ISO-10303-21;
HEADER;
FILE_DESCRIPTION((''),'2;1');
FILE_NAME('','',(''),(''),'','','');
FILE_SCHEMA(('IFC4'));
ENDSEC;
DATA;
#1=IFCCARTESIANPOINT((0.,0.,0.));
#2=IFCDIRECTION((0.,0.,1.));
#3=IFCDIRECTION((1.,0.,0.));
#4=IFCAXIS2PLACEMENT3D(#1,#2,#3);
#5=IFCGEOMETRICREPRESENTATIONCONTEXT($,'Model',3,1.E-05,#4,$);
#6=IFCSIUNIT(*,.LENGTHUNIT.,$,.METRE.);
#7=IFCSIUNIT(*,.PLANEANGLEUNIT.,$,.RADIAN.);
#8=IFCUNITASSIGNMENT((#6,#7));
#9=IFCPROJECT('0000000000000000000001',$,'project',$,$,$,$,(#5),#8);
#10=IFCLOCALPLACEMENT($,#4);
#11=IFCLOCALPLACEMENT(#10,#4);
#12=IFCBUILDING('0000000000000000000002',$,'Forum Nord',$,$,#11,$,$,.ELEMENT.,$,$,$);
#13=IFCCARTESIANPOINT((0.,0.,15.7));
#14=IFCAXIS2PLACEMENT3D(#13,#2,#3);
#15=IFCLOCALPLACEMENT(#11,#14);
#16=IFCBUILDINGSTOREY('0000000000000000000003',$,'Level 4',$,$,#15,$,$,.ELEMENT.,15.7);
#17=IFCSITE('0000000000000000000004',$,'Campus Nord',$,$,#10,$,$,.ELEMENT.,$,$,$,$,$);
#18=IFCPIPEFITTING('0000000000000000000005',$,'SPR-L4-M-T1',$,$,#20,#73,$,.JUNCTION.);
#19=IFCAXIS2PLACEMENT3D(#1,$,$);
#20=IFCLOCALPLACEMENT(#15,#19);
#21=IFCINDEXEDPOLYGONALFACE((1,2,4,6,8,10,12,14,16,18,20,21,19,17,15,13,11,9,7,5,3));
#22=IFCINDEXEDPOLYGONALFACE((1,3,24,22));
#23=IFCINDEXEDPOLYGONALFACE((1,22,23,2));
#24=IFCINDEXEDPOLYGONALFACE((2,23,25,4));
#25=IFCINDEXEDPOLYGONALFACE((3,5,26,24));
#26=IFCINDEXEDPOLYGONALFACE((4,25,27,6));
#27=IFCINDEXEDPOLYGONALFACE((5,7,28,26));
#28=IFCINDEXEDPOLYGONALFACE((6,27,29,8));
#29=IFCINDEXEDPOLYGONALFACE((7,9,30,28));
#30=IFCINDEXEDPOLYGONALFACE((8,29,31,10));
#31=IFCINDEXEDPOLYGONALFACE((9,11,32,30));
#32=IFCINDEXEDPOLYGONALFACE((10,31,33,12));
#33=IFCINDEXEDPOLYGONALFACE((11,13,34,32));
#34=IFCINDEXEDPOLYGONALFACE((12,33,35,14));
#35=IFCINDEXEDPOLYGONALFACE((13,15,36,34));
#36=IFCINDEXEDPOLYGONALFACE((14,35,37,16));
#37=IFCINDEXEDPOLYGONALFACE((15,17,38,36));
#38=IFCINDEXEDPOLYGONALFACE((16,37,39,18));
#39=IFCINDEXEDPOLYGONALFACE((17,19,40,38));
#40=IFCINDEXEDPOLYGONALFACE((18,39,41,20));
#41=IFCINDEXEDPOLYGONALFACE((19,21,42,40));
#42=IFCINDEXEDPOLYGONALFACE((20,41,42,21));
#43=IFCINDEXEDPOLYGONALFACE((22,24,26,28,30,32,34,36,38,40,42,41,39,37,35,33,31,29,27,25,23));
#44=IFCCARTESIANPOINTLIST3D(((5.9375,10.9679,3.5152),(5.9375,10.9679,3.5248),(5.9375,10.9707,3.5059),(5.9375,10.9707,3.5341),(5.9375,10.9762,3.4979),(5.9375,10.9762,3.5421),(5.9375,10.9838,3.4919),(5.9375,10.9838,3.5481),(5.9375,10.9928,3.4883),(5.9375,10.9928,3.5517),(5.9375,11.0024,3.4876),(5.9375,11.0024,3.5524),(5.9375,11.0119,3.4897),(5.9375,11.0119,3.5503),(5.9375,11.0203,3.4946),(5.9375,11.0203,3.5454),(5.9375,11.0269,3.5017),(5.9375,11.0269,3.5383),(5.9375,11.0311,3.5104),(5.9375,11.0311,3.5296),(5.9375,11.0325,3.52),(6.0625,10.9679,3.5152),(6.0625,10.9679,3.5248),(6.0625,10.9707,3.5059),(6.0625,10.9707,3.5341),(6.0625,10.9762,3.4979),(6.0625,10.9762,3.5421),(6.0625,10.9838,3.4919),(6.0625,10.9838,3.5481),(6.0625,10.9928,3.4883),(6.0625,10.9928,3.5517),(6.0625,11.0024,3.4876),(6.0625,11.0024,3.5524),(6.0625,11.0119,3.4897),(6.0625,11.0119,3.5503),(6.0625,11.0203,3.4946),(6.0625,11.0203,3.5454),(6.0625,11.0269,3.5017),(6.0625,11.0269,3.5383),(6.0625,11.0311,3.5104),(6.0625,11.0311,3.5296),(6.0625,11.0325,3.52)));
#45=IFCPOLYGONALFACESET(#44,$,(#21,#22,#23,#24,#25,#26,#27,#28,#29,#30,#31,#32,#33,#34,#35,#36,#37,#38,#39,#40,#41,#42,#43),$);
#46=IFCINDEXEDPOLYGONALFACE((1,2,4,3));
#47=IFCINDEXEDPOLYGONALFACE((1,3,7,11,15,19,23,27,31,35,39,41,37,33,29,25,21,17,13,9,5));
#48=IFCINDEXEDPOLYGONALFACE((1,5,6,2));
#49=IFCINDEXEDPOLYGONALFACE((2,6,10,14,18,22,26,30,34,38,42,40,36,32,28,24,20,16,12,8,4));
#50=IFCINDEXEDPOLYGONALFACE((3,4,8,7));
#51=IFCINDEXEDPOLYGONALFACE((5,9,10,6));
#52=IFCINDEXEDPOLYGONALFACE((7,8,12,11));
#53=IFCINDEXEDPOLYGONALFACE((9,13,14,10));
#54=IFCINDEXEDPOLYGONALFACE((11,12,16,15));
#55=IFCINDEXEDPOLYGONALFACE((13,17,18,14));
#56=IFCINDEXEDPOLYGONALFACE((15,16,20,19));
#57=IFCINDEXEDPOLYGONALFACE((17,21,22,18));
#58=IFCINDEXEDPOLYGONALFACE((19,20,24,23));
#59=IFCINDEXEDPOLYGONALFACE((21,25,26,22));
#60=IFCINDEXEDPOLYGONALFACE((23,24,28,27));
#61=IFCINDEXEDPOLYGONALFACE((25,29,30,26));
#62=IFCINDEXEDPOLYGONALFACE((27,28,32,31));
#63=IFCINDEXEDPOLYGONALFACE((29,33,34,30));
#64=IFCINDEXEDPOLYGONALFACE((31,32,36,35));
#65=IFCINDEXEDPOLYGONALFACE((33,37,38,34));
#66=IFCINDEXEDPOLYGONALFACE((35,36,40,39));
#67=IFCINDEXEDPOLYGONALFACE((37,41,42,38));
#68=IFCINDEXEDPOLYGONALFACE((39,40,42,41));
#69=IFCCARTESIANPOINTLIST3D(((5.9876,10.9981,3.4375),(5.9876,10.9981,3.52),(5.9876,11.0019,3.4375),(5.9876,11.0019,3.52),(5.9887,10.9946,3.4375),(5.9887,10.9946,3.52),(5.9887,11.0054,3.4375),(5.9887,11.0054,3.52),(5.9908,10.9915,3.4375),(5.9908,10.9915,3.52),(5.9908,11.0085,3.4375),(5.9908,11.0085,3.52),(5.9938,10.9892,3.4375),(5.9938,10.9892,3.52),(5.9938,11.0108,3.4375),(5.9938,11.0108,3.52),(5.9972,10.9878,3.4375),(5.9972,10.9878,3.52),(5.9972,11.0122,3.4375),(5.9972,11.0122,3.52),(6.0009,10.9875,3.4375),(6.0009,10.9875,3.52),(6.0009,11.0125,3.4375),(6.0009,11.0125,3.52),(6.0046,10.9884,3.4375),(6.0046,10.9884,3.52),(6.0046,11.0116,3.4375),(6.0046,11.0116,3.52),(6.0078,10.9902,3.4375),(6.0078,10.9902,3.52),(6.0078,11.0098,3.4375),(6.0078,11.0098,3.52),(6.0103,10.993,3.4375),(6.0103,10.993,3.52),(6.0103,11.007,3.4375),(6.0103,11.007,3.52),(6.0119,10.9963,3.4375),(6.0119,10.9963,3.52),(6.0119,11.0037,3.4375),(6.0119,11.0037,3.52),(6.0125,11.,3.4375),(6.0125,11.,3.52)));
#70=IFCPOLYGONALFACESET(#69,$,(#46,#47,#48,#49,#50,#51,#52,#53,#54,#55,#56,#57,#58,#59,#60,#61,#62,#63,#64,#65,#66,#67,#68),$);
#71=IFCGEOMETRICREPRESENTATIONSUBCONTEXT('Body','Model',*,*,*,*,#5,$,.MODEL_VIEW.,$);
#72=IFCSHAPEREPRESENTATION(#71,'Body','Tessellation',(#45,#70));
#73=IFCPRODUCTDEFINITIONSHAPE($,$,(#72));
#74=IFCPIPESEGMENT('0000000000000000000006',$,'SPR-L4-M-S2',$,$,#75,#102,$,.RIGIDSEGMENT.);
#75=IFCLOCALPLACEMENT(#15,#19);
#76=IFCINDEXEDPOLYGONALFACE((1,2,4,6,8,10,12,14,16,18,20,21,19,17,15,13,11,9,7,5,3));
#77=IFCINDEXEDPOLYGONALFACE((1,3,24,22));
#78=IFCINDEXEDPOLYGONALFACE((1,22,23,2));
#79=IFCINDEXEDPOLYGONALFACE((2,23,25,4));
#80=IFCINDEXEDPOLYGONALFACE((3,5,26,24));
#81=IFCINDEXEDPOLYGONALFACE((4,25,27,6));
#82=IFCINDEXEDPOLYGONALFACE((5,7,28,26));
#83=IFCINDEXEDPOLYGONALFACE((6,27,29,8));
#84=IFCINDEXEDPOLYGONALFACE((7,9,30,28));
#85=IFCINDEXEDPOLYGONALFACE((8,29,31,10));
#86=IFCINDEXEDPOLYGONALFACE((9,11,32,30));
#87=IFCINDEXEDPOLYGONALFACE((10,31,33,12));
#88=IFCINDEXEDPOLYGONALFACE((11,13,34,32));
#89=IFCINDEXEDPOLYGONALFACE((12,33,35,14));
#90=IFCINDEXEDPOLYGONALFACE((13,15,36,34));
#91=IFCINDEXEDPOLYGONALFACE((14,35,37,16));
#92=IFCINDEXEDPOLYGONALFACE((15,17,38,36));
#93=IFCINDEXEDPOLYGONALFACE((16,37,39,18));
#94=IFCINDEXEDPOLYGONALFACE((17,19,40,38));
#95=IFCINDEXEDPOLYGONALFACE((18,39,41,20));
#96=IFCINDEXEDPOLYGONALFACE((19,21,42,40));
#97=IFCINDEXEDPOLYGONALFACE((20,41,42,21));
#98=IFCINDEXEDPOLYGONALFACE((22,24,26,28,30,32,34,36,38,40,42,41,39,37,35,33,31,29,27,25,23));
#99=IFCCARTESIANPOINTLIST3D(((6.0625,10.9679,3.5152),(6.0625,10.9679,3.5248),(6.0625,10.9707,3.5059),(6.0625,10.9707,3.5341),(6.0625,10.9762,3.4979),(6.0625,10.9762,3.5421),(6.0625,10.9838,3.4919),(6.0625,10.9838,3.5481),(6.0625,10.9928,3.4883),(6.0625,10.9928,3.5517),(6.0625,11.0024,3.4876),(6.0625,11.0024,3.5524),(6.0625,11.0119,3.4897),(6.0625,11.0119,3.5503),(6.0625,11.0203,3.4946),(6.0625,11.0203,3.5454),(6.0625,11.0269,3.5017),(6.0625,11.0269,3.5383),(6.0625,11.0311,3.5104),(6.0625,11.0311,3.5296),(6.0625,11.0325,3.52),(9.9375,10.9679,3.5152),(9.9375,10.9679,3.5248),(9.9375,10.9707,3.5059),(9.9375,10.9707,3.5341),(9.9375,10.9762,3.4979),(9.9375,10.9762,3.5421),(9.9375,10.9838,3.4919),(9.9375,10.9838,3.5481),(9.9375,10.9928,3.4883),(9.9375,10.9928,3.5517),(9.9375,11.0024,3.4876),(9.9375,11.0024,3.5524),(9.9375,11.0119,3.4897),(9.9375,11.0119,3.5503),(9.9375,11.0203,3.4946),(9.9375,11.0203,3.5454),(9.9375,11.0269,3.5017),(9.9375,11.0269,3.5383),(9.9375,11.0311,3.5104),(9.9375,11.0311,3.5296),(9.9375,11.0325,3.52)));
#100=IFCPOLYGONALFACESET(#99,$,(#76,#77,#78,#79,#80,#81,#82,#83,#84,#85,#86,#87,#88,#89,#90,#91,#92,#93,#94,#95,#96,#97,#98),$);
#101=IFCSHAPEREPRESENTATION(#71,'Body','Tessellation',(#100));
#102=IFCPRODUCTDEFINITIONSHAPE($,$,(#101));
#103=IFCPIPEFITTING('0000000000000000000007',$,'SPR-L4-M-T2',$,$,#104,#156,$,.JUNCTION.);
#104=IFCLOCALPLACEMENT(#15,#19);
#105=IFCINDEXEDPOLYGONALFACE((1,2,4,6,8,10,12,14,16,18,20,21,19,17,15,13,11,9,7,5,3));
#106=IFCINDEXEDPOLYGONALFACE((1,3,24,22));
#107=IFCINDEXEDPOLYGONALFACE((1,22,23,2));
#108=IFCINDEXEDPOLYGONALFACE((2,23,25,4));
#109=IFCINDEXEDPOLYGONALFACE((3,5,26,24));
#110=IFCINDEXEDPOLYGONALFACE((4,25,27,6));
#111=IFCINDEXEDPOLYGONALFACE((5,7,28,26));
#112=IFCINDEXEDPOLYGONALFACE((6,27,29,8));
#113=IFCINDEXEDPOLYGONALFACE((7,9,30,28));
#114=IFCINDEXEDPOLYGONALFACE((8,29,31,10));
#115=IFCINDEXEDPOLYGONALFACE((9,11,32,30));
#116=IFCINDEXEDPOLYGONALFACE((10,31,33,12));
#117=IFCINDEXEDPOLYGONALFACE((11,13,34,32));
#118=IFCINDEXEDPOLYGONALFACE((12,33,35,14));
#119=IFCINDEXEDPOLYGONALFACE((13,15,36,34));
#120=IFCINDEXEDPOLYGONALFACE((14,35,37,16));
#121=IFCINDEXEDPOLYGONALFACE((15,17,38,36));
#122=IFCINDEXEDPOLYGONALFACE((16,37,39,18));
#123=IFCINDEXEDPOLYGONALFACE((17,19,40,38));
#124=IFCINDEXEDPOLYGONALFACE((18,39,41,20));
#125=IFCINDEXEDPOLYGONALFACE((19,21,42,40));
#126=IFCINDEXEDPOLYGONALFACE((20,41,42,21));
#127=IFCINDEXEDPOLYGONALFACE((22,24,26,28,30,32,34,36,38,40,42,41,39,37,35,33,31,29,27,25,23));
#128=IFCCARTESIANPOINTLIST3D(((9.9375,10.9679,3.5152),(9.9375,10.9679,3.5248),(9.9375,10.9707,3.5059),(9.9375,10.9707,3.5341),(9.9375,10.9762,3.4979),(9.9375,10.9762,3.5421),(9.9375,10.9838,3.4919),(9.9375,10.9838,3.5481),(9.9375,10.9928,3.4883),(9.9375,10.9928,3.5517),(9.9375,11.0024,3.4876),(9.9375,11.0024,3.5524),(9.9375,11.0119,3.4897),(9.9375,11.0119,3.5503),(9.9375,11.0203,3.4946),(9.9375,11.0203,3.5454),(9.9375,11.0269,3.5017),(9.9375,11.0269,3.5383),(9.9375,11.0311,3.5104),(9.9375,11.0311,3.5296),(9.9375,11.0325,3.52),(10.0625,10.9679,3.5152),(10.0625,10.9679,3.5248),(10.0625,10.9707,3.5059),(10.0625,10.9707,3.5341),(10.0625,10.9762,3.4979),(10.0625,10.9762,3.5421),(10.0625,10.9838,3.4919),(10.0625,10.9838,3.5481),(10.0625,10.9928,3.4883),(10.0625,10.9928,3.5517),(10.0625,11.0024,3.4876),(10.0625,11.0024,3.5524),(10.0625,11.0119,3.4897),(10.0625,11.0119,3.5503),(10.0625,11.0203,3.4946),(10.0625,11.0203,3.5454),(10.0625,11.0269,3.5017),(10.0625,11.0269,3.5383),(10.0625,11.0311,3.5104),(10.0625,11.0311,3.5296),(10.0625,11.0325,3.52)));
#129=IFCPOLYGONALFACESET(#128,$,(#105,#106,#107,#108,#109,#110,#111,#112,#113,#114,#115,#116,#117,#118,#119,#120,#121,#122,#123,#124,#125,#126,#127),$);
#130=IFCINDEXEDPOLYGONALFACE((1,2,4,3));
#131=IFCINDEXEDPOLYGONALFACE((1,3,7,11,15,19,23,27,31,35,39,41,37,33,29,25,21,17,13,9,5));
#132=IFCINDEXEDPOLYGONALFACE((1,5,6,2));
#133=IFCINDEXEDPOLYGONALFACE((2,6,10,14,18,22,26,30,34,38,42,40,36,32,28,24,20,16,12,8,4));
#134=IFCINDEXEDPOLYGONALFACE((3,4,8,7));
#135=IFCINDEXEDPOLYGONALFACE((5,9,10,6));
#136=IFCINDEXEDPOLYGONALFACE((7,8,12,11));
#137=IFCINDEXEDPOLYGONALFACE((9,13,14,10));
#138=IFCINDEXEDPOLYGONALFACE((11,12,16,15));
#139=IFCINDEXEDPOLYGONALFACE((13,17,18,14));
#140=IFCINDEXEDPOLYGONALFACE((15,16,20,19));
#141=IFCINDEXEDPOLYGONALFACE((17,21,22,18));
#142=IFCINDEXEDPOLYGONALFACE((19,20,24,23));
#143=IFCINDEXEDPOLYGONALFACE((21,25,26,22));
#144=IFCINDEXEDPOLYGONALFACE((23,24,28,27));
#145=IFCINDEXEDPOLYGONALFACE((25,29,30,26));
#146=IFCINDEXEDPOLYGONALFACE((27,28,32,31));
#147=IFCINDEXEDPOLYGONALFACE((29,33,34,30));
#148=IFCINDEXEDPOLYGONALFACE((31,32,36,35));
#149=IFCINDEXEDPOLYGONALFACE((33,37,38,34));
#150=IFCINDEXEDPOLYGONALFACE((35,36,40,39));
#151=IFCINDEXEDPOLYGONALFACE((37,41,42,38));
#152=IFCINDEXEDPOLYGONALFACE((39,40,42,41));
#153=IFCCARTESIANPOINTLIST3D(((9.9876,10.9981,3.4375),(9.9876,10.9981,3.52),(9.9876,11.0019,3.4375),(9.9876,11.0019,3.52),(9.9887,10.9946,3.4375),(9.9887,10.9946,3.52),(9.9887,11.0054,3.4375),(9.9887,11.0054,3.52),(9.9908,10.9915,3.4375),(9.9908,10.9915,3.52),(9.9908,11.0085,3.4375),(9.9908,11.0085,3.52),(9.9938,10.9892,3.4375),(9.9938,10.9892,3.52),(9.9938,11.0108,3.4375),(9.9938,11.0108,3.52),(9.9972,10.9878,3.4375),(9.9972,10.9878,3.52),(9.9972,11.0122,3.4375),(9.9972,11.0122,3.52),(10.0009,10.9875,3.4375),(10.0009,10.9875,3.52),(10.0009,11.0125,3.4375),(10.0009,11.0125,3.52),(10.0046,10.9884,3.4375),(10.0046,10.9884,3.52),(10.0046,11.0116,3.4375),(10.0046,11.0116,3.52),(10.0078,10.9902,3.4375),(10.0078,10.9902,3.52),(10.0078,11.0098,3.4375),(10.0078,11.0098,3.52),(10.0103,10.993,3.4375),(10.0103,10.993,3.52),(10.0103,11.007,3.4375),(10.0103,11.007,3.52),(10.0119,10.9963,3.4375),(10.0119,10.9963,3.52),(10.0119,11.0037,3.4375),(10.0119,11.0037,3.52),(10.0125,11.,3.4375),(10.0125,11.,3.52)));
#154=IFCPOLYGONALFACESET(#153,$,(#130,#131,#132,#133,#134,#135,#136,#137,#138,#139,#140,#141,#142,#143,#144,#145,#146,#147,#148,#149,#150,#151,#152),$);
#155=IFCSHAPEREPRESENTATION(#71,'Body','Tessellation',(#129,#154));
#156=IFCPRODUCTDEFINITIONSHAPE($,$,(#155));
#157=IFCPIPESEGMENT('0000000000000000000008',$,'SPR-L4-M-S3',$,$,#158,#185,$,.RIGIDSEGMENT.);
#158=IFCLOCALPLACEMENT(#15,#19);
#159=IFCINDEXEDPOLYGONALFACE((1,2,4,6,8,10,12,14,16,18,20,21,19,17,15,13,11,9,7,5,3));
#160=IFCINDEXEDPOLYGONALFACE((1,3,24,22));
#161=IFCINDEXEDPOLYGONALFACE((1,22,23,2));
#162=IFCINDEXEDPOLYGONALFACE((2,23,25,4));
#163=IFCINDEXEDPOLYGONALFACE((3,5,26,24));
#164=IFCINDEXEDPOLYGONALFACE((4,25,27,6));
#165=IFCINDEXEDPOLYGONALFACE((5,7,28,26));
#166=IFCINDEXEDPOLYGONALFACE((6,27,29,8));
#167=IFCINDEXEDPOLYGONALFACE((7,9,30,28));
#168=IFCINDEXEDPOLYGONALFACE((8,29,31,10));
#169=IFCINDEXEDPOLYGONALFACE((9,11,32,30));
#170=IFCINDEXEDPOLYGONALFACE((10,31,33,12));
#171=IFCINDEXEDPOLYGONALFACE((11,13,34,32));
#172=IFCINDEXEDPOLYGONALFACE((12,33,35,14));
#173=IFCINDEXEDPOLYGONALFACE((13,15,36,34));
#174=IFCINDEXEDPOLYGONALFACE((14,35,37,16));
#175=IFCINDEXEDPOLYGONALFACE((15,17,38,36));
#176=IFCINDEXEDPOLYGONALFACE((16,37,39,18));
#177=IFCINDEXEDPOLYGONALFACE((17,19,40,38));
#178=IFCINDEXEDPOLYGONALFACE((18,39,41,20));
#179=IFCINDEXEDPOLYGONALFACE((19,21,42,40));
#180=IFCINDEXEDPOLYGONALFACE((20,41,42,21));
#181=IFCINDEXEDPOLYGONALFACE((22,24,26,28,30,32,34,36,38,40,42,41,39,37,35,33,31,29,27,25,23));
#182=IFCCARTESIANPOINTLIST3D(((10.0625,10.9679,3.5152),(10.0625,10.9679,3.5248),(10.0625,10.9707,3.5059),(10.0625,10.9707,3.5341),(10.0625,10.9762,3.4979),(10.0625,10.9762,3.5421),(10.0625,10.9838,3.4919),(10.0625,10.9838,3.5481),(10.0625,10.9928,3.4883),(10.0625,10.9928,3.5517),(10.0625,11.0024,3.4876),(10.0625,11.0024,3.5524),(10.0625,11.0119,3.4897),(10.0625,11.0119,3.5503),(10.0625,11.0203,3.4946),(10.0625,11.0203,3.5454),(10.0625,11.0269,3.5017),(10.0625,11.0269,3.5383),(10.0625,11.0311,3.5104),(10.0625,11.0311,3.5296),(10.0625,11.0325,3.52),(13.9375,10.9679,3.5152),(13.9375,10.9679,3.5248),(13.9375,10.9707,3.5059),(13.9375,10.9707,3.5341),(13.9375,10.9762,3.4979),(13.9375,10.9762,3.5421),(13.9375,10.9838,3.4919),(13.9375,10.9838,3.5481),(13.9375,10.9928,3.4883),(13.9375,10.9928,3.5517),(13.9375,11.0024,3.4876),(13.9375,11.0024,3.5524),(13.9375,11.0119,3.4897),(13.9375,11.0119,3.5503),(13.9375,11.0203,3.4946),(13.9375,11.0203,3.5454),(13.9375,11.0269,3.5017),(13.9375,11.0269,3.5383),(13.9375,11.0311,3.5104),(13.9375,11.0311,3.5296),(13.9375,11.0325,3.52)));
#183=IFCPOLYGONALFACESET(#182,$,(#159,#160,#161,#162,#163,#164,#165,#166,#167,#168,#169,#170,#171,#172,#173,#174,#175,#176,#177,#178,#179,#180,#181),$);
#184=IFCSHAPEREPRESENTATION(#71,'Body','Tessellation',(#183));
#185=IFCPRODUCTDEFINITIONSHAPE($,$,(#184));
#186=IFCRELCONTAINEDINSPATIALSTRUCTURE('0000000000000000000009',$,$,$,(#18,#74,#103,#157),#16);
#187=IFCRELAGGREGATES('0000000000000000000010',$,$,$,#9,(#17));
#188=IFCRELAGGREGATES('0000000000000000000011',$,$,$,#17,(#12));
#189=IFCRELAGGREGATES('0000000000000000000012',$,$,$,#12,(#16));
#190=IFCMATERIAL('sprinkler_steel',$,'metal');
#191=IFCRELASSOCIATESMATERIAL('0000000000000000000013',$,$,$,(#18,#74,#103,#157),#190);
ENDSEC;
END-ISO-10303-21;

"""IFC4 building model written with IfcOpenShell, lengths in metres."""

from ifc_helpers import new_model, si_unit, frame, origin_with_axes, origin_2d_with_axis, place, context, subcontext, project, spatial, circle, extrude, material, element, save


model = new_model("IFC4")

# Units and contexts
model_context = context("Model", 3, precision=1e-05, world=origin_with_axes())
body_context = subcontext(model_context, "Body", "Model", "MODEL_VIEW")
ifc_project = project(units=[si_unit("LENGTHUNIT", "METRE"), si_unit("PLANEANGLEUNIT", "RADIAN")], contexts=[model_context])

# Site, building, storey
site_placement = place(None, origin_with_axes())
site = spatial("IfcSite", under=ifc_project, at=site_placement, Name="Campus Nord", CompositionType="ELEMENT")
building_placement = place(site_placement, origin_with_axes())
building = spatial("IfcBuilding", under=site, at=building_placement, Name="Forum Nord", CompositionType="ELEMENT")
storey_placement = place(building_placement, frame((0.0, 0.0, 15.7), z_axis=(0.0, 0.0, 1.0), x_axis=(1.0, 0.0, 0.0)))
storey = spatial("IfcBuildingStorey", under=building, at=storey_placement, Name="Level 4", CompositionType="ELEMENT", Elevation=15.7)

# Shared definitions
ifc_material_1 = material(Name="sprinkler_steel", Category="metal")

# Pipe fitting
pipe_fitting_1_placement = place(storey_placement, frame((5.9375, 11.0, 3.52), z_axis=(1.0, 0.0, 0.0), x_axis=(0.0, 1.0, 0.0)))
element("IfcPipeFitting", 1, at=pipe_fitting_1_placement, inside=storey, material=ifc_material_1, Name="SPR-L4-M-T1", PredefinedType="JUNCTION", context=body_context, shape_type="SweptSolid", body=[
    extrude(circle(Radius=0.0325, at=origin_2d_with_axis()), origin_with_axes(), (0.0, 0.0, 1.0), 0.125),
    extrude(circle(Radius=0.0125, at=origin_2d_with_axis()), frame((0.0, 0.0, 0.0625), z_axis=(0.0, -1.0, 0.0), x_axis=(0.0, 0.0, 1.0)), (0.0, 0.0, 1.0), 0.0825),
])

# Pipe segment
pipe_segment_1_placement = place(storey_placement, frame((6.0625, 11.0, 3.52), z_axis=(1.0, 0.0, 0.0), x_axis=(0.0, 1.0, 0.0)))
element("IfcPipeSegment", 2, at=pipe_segment_1_placement, inside=storey, material=ifc_material_1, Name="SPR-L4-M-S2", PredefinedType="RIGIDSEGMENT", context=body_context, shape_type="SweptSolid", body=[
    extrude(circle(Radius=0.0325, at=origin_2d_with_axis()), origin_with_axes(), (0.0, 0.0, 1.0), 3.875),
])

# Pipe fitting
pipe_fitting_2_placement = place(storey_placement, frame((9.9375, 11.0, 3.52), z_axis=(1.0, 0.0, 0.0), x_axis=(0.0, 1.0, 0.0)))
element("IfcPipeFitting", 3, at=pipe_fitting_2_placement, inside=storey, material=ifc_material_1, Name="SPR-L4-M-T2", PredefinedType="JUNCTION", context=body_context, shape_type="SweptSolid", body=[
    extrude(circle(Radius=0.0325, at=origin_2d_with_axis()), origin_with_axes(), (0.0, 0.0, 1.0), 0.125),
    extrude(circle(Radius=0.0125, at=origin_2d_with_axis()), frame((0.0, 0.0, 0.0625), z_axis=(0.0, -1.0, 0.0), x_axis=(0.0, 0.0, 1.0)), (0.0, 0.0, 1.0), 0.0825),
])

# Pipe segment
pipe_segment_2_placement = place(storey_placement, frame((10.0625, 11.0, 3.52), z_axis=(1.0, 0.0, 0.0), x_axis=(0.0, 1.0, 0.0)))
element("IfcPipeSegment", 4, at=pipe_segment_2_placement, inside=storey, material=ifc_material_1, Name="SPR-L4-M-S3", PredefinedType="RIGIDSEGMENT", context=body_context, shape_type="SweptSolid", body=[
    extrude(circle(Radius=0.0325, at=origin_2d_with_axis()), origin_with_axes(), (0.0, 0.0, 1.0), 3.875),
])

save(model, "model.ifc")
